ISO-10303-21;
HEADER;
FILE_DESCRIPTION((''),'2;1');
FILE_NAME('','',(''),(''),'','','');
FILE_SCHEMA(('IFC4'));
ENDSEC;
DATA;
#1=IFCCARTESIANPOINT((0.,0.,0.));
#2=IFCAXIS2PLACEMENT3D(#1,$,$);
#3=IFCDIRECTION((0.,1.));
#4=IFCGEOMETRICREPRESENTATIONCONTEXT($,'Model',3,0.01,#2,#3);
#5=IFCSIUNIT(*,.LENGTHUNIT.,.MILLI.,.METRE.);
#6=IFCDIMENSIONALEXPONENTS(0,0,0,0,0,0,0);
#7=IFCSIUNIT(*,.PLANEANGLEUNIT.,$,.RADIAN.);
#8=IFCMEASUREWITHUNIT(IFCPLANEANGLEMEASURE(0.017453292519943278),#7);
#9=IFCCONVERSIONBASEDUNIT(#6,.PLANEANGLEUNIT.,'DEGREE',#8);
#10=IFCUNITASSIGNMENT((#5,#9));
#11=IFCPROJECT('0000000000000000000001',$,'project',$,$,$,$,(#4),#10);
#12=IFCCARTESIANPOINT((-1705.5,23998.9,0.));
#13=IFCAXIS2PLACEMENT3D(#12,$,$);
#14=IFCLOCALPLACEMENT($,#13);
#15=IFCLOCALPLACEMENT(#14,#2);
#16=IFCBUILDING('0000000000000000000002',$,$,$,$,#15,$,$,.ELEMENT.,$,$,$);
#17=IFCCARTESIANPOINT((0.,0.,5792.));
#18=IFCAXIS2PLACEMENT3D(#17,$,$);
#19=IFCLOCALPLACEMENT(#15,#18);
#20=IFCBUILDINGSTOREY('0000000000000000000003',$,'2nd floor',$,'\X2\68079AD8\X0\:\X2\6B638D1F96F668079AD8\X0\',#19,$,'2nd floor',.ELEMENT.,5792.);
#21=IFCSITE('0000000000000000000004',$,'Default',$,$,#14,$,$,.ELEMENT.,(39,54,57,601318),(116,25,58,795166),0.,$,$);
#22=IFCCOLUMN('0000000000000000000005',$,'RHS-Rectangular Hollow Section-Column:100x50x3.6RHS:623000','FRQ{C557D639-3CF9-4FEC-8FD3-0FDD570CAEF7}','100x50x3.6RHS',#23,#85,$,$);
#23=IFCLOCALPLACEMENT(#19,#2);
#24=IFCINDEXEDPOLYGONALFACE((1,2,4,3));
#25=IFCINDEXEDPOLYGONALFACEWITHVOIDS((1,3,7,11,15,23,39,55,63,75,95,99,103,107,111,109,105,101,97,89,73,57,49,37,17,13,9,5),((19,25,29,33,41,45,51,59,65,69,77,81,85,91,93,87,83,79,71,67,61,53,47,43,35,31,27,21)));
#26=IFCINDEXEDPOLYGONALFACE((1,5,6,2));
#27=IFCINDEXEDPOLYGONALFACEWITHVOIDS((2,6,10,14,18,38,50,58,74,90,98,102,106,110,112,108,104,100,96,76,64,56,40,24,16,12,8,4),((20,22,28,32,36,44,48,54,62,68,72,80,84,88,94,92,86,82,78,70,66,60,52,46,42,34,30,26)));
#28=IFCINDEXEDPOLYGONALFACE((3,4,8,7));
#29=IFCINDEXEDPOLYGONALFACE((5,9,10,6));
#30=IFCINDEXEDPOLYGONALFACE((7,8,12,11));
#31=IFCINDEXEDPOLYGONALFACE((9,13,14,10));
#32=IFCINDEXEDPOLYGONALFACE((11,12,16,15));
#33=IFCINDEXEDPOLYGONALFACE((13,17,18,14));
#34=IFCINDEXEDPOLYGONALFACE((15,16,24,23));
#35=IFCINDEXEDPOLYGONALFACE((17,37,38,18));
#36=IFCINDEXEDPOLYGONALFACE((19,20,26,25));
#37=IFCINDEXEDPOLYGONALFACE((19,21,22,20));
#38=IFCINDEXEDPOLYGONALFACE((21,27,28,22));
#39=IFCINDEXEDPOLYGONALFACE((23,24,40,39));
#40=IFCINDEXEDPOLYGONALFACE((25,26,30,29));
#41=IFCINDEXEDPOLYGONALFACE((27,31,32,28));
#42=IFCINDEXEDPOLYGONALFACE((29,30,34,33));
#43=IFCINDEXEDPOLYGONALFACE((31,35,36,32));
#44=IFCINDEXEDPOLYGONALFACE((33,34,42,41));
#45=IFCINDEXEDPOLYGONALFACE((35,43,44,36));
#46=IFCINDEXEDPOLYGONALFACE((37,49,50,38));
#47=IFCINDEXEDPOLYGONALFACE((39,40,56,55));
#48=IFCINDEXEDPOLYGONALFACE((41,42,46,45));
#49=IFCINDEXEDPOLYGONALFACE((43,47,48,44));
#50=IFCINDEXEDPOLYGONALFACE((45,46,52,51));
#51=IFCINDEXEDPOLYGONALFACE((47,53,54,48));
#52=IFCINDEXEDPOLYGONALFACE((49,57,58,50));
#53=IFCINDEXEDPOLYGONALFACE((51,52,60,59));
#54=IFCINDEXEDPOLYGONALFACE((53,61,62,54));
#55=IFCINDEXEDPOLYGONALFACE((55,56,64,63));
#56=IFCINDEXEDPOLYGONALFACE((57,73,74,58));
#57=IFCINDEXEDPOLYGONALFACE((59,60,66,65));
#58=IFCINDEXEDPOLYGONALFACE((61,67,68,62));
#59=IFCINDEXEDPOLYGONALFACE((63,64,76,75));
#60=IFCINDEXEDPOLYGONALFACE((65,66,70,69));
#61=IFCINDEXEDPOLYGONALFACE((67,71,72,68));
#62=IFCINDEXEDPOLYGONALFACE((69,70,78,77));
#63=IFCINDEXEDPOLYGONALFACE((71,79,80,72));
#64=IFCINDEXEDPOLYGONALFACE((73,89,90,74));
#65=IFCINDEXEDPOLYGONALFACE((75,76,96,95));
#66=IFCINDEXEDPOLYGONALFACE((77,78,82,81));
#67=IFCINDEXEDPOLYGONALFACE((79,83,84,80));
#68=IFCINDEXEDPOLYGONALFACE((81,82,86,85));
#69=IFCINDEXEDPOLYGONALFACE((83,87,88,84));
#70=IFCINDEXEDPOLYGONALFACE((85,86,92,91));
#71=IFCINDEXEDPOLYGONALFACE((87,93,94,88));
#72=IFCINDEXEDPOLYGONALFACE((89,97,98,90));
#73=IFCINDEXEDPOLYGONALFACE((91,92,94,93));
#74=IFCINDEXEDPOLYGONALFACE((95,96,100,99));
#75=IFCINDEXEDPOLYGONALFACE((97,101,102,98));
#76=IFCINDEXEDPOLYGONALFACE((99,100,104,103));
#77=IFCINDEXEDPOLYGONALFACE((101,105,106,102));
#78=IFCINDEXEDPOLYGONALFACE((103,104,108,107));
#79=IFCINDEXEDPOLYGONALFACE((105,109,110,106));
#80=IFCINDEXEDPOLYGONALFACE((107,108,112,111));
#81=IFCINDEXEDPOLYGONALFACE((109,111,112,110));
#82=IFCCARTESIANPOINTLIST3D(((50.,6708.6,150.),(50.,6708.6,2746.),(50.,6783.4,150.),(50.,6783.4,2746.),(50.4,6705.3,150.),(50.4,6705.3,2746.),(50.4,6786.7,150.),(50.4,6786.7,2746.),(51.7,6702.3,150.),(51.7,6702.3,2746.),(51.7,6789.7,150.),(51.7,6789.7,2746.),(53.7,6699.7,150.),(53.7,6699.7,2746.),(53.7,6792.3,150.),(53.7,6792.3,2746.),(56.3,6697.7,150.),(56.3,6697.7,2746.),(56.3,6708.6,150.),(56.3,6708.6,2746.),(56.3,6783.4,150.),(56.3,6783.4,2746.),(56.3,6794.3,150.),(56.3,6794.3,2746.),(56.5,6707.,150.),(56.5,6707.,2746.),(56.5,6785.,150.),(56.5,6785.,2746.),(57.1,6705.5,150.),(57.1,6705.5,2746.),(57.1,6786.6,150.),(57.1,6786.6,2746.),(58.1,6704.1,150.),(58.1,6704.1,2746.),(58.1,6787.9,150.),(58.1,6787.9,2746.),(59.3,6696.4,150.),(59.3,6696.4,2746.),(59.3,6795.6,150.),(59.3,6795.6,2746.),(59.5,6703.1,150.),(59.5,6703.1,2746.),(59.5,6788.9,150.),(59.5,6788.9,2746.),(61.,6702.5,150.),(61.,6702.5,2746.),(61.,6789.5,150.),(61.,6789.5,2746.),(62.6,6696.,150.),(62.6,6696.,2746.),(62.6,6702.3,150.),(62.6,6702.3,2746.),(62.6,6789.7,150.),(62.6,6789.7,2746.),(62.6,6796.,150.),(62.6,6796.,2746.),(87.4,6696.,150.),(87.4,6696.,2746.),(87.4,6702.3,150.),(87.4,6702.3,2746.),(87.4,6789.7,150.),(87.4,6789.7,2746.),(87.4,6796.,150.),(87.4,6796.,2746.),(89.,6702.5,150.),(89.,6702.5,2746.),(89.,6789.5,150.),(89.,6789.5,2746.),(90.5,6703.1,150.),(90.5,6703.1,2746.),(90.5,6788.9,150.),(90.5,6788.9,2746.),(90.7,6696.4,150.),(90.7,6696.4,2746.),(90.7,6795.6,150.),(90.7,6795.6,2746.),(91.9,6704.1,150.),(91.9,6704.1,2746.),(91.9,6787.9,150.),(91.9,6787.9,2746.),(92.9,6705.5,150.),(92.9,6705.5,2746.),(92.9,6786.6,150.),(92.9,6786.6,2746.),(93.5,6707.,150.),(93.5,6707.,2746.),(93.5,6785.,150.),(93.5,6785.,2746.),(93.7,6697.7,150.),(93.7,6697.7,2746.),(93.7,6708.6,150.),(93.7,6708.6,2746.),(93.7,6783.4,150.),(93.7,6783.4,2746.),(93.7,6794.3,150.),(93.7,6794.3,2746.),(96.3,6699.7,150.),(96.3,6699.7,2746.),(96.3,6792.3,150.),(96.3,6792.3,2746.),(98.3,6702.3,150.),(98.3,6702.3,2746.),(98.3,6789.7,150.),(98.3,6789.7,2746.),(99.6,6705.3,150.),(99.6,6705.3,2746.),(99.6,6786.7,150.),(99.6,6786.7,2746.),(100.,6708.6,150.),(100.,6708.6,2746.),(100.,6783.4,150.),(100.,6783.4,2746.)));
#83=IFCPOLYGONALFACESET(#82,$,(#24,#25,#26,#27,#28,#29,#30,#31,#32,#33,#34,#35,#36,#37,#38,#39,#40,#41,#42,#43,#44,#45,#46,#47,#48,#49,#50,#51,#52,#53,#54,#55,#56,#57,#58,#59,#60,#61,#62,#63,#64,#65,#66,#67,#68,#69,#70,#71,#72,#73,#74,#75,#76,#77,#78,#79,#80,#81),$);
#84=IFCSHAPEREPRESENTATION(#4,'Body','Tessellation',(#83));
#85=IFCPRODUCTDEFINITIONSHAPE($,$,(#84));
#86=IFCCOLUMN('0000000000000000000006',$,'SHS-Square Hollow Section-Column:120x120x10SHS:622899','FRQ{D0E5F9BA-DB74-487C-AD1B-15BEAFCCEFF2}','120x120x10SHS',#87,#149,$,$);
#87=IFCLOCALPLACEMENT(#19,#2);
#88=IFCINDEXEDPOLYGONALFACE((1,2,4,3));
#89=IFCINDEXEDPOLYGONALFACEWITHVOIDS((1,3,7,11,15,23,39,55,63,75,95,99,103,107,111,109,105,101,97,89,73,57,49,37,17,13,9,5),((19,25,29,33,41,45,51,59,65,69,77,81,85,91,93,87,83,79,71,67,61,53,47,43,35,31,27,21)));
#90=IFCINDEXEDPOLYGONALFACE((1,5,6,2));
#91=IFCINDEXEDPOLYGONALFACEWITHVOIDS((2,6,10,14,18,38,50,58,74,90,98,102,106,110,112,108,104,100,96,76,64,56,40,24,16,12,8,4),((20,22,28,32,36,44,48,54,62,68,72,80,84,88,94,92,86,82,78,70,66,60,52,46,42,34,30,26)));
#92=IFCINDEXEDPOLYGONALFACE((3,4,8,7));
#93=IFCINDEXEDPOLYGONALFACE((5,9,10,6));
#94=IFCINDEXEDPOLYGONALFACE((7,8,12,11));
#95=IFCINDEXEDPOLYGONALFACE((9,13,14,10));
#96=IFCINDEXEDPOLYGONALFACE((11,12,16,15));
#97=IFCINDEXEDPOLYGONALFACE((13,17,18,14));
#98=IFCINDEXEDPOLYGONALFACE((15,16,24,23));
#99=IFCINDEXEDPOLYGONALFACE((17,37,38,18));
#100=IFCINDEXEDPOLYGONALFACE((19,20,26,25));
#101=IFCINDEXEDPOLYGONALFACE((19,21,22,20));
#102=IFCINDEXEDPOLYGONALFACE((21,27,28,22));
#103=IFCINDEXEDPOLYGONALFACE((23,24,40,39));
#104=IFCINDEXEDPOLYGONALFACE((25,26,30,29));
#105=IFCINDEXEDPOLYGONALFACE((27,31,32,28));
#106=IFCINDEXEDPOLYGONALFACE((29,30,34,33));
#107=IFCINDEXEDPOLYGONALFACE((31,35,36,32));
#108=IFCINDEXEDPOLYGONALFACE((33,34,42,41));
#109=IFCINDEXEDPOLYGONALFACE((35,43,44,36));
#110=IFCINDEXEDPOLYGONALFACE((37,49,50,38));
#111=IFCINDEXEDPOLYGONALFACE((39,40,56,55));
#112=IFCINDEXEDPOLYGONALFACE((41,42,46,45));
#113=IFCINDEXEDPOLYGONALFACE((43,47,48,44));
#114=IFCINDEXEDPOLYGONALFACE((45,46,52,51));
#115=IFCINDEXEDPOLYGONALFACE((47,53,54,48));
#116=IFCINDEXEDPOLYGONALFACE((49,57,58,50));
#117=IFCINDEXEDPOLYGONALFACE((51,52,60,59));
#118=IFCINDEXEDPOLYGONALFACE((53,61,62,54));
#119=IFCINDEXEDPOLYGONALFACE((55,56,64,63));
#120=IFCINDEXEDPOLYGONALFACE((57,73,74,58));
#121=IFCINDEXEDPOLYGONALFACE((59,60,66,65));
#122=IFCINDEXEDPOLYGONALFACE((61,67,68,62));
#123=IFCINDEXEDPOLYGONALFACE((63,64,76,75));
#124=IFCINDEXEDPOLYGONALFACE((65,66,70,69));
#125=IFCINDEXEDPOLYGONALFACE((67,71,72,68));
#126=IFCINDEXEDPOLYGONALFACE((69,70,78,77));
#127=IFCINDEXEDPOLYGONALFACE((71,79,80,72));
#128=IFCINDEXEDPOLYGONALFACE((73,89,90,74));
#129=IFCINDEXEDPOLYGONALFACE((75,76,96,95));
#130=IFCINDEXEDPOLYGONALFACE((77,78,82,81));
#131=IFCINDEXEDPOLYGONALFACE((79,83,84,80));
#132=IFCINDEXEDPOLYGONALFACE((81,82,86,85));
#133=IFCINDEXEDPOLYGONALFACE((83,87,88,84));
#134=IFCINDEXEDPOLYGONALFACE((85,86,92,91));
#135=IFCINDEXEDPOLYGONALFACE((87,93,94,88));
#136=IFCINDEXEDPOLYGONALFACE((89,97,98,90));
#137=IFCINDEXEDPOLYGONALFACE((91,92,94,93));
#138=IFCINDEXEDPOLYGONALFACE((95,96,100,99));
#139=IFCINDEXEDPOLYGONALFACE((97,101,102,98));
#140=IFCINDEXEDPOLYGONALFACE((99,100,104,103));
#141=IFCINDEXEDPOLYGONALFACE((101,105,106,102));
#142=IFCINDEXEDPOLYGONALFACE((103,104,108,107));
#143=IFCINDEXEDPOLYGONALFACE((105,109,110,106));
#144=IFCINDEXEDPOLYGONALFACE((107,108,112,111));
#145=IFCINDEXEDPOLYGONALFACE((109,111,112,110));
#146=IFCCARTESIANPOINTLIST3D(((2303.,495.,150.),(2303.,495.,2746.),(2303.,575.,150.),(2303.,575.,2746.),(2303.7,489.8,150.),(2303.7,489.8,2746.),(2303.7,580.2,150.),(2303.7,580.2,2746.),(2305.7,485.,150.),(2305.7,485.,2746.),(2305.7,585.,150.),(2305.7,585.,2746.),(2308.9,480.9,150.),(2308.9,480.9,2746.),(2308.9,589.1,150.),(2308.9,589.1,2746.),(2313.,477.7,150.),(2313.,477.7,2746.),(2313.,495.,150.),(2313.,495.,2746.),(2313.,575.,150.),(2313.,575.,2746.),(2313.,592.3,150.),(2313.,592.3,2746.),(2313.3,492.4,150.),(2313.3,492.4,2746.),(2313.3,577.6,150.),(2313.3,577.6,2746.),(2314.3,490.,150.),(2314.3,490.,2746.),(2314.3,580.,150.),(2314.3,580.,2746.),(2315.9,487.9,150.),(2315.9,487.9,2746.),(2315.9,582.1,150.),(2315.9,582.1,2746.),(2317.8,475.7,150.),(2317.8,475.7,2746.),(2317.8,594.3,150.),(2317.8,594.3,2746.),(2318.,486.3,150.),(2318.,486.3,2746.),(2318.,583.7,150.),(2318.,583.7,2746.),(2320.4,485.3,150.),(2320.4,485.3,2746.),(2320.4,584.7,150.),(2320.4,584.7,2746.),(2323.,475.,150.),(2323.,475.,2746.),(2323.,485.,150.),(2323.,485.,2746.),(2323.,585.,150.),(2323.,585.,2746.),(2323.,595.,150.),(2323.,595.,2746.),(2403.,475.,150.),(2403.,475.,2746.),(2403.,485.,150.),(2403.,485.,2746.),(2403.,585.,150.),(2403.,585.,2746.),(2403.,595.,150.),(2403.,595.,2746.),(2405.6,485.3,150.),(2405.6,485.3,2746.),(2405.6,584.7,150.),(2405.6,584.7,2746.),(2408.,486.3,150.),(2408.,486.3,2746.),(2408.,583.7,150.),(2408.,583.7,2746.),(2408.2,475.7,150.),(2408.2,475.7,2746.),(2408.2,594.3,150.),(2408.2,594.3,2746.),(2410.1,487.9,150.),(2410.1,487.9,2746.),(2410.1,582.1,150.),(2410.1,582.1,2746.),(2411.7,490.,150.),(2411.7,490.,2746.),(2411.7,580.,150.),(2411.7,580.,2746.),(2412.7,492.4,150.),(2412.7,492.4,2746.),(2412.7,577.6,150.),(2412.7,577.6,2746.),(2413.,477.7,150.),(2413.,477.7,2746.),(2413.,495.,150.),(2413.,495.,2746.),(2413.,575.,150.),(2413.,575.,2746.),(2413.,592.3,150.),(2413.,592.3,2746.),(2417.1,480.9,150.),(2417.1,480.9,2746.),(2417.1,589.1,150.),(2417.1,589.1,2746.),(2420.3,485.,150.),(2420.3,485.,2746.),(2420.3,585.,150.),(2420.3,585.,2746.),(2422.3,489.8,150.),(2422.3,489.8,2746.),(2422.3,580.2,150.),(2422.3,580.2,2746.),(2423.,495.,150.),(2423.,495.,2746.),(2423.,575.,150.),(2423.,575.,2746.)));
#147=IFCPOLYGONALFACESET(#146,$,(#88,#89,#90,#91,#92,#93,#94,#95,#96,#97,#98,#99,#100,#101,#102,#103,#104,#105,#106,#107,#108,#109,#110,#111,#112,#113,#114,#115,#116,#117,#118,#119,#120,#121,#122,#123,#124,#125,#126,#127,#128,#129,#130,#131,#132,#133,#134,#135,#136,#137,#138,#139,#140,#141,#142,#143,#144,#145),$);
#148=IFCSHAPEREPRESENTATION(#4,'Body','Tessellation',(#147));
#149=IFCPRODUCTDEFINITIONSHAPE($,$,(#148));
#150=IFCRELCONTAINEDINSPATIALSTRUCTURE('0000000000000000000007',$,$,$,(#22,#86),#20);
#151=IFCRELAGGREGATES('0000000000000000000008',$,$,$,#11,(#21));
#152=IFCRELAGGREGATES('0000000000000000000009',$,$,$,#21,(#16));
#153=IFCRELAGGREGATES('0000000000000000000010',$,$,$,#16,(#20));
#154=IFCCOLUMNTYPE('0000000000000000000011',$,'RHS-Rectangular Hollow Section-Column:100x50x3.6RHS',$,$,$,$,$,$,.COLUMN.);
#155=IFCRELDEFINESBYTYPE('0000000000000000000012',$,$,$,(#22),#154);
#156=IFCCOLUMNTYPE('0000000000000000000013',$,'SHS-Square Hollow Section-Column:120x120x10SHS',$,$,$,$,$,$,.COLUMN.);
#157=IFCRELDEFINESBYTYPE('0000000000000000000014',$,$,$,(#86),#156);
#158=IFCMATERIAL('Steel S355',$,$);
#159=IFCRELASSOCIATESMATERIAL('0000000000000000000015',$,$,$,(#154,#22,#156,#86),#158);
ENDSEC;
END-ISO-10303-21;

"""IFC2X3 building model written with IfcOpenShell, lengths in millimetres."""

from ifc_helpers import new_model, entity, si_unit, converted_unit, direction, frame, origin, origin_2d, place, context, project, spatial, hollow_rectangle, extrude, clip, halfspace, material, type_object, element, save


model = new_model("IFC2X3")

# Units and contexts
model_context = context("Model", 3, precision=0.01, world=origin(), true_north=direction((0.0, 1.0)))
ifc_project = project(units=[si_unit("LENGTHUNIT", "METRE", prefix="MILLI"), converted_unit("PLANEANGLEUNIT", "DEGREE", entity("IfcPlaneAngleMeasure", 0.017453292519943278), si_unit("PLANEANGLEUNIT", "RADIAN"), dimensions=[0, 0, 0, 0, 0, 0, 0])], contexts=[model_context])

# Site, building, storey
site_placement = place(None, frame((-1705.5, 23998.9, 0.0)))
site = spatial("IfcSite", under=ifc_project, at=site_placement, Name="Default", CompositionType="ELEMENT", RefLatitude=(39, 54, 57, 601318), RefLongitude=(116, 25, 58, 795166), RefElevation=0.0)
building_placement = place(site_placement, origin())
building = spatial("IfcBuilding", under=site, at=building_placement, CompositionType="ELEMENT")
storey_placement = place(building_placement, frame((0.0, 0.0, 5792.0)))
storey = spatial("IfcBuildingStorey", under=building, at=storey_placement, Name="2nd floor", ObjectType="标高:正负零标高", LongName="2nd floor", CompositionType="ELEMENT", Elevation=5792.0)

# Shared definitions
ifc_material_1 = material(Name="Steel S355")

# Columns
column_type_1 = type_object("IfcColumnType", Name="RHS-Rectangular Hollow Section-Column:100x50x3.6RHS", PredefinedType="COLUMN", material=ifc_material_1)
column_1_placement = place(storey_placement, frame((75.0, 6746.0, 2746.0), z_axis=(0.0, 0.0, 1.0), x_axis=(-1.0, 0.0, 0.0)))
element("IfcColumn", 1, at=column_1_placement, inside=storey, type_object=column_type_1, material=ifc_material_1, Name="RHS-Rectangular Hollow Section-Column:100x50x3.6RHS:623000", Description="FRQ{C557D639-3CF9-4FEC-8FD3-0FDD570CAEF7}", ObjectType="100x50x3.6RHS", context=model_context, shape_type="Clipping", body=[
    clip(extrude(hollow_rectangle(XDim=50.0, YDim=100.0, WallThickness=6.3, InnerFilletRadius=6.3, OuterFilletRadius=12.6, at=origin_2d()), origin(), (0.0, 0.0, -1.0), 2651.9), halfspace(frame((75.0, 6746.0, -2596.0), z_axis=(0.0, 0.0, 1.0), x_axis=(-1.0, 0.0, 0.0)), True)),
])
column_type_2 = type_object("IfcColumnType", Name="SHS-Square Hollow Section-Column:120x120x10SHS", PredefinedType="COLUMN", material=ifc_material_1)
column_2_placement = place(storey_placement, frame((2363.0, 535.0, 2746.0), z_axis=(0.0, 0.0, 1.0), x_axis=(0.0, -1.0, 0.0)))
element("IfcColumn", 2, at=column_2_placement, inside=storey, type_object=column_type_2, material=ifc_material_1, Name="SHS-Square Hollow Section-Column:120x120x10SHS:622899", Description="FRQ{D0E5F9BA-DB74-487C-AD1B-15BEAFCCEFF2}", ObjectType="120x120x10SHS", context=model_context, shape_type="Clipping", body=[
    clip(extrude(hollow_rectangle(XDim=120.0, YDim=120.0, WallThickness=10.0, InnerFilletRadius=10.0, OuterFilletRadius=20.0, at=origin_2d()), origin(), (0.0, 0.0, -1.0), 2680.9), halfspace(frame((535.0, -2363.0, -2596.0), z_axis=(0.0, 0.0, 1.0), x_axis=(0.0, 1.0, 0.0)), True)),
])

save(model, "model.ifc")
